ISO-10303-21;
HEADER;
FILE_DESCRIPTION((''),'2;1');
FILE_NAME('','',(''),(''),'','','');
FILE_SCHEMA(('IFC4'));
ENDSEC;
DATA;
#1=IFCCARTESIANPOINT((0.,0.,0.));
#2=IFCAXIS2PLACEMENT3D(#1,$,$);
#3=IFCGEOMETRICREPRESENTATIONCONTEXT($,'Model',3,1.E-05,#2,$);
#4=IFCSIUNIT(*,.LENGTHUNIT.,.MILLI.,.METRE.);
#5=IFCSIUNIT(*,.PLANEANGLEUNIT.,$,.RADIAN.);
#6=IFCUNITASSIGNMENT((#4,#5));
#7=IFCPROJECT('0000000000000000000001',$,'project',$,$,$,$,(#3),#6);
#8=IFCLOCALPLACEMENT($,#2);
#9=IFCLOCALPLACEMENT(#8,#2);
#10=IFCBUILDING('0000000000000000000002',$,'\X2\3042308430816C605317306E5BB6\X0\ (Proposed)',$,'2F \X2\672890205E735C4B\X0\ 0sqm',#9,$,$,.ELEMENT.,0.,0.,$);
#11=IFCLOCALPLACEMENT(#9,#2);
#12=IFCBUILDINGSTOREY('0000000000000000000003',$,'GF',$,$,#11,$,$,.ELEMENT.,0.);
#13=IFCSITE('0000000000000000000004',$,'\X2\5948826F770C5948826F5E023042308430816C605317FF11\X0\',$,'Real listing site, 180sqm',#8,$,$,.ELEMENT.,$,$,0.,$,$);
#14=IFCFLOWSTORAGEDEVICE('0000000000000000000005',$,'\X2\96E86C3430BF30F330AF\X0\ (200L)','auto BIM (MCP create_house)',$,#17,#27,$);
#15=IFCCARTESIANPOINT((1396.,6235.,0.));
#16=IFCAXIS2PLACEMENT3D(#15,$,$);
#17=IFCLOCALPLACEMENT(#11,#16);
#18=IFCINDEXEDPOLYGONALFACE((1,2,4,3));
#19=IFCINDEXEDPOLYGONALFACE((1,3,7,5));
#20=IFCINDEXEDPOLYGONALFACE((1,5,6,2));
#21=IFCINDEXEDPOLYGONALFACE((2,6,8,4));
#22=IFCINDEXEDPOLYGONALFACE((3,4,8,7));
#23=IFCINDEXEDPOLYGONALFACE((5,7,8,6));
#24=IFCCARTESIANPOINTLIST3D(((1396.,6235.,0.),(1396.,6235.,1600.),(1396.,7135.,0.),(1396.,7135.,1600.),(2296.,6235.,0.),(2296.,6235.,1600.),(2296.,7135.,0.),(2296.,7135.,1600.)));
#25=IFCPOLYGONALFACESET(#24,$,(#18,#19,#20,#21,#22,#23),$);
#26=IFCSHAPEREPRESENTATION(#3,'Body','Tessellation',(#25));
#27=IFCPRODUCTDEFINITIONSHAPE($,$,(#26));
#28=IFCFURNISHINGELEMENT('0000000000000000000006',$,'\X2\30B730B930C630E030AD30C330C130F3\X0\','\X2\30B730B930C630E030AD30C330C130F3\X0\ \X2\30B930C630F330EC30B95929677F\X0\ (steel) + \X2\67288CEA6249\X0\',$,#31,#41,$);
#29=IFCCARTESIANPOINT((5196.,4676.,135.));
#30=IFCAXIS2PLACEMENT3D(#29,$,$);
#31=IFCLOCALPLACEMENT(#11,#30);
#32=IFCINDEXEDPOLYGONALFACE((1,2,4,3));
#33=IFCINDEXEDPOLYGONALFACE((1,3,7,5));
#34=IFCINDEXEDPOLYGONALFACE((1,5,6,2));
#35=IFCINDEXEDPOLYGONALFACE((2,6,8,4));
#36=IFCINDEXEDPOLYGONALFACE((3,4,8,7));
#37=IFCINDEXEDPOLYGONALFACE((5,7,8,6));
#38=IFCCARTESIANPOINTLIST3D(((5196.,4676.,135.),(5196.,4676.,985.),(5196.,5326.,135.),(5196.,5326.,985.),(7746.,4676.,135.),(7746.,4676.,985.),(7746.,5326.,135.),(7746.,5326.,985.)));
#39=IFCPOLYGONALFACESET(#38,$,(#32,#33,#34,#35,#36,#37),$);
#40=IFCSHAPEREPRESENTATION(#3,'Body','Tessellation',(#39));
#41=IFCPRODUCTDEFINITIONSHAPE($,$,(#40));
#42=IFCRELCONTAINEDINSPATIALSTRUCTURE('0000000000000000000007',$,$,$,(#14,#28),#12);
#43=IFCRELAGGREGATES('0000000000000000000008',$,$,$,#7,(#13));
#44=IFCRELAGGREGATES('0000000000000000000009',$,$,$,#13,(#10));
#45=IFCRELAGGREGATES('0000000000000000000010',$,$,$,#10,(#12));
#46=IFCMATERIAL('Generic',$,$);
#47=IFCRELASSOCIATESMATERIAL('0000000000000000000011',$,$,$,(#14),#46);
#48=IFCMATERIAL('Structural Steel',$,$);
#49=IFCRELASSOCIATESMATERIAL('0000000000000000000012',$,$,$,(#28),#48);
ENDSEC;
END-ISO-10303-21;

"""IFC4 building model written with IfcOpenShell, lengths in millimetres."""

from ifc_helpers import new_model, si_unit, frame, frame_2d, origin, place, context, project, spatial, rectangle, extrude, material, element, save


model = new_model("IFC4")

# Units and contexts
model_context = context("Model", 3, precision=1e-05, world=origin())
ifc_project = project(units=[si_unit("LENGTHUNIT", "METRE", prefix="MILLI"), si_unit("PLANEANGLEUNIT", "RADIAN")], contexts=[model_context])

# Site, building, storey
site_placement = place(None, origin())
site = spatial("IfcSite", under=ifc_project, at=site_placement, Name="奈良県奈良市あやめ池北１", ObjectType="Real listing site, 180sqm", CompositionType="ELEMENT", RefElevation=0.0)
building_placement = place(site_placement, origin())
building = spatial("IfcBuilding", under=site, at=building_placement, Name="あやめ池北の家 (Proposed)", ObjectType="2F 木造平屋 0sqm", CompositionType="ELEMENT", ElevationOfRefHeight=0.0, ElevationOfTerrain=0.0)
storey_placement = place(building_placement, origin())
storey = spatial("IfcBuildingStorey", under=building, at=storey_placement, Name="GF", CompositionType="ELEMENT", Elevation=0.0)

# Shared definitions
ifc_material_1 = material(Name="Generic")

# Flow storage device
flow_storage_device_placement = place(storey_placement, frame((1396.0, 6235.0, 0.0)))
element("IfcFlowStorageDevice", 1, at=flow_storage_device_placement, inside=storey, material=ifc_material_1, Name="雨水タンク (200L)", Description="auto BIM (MCP create_house)", context=model_context, shape_type="SweptSolid", body=[
    extrude(rectangle(XDim=900.0, YDim=900.0, at=frame_2d((450.0, 450.0))), frame((1396.0, 6235.0, 0.0)), (0.0, 0.0, 1.0), 1600.0),
])

# Furnishing element
ifc_material_2 = material(Name="Structural Steel")
furnishing_placement = place(storey_placement, frame((5196.0, 4676.0, 135.0)))
element("IfcFurnishingElement", 2, at=furnishing_placement, inside=storey, material=ifc_material_2, Name="システムキッチン", Description="システムキッチン ステンレス天板 (steel) + 木質扉", context=model_context, shape_type="SweptSolid", body=[
    extrude(rectangle(XDim=2550.0, YDim=650.0, at=frame_2d((1275.0, 325.0))), frame((5196.0, 4676.0, 135.0)), (0.0, 0.0, 1.0), 850.0),
])

save(model, "model.ifc")
